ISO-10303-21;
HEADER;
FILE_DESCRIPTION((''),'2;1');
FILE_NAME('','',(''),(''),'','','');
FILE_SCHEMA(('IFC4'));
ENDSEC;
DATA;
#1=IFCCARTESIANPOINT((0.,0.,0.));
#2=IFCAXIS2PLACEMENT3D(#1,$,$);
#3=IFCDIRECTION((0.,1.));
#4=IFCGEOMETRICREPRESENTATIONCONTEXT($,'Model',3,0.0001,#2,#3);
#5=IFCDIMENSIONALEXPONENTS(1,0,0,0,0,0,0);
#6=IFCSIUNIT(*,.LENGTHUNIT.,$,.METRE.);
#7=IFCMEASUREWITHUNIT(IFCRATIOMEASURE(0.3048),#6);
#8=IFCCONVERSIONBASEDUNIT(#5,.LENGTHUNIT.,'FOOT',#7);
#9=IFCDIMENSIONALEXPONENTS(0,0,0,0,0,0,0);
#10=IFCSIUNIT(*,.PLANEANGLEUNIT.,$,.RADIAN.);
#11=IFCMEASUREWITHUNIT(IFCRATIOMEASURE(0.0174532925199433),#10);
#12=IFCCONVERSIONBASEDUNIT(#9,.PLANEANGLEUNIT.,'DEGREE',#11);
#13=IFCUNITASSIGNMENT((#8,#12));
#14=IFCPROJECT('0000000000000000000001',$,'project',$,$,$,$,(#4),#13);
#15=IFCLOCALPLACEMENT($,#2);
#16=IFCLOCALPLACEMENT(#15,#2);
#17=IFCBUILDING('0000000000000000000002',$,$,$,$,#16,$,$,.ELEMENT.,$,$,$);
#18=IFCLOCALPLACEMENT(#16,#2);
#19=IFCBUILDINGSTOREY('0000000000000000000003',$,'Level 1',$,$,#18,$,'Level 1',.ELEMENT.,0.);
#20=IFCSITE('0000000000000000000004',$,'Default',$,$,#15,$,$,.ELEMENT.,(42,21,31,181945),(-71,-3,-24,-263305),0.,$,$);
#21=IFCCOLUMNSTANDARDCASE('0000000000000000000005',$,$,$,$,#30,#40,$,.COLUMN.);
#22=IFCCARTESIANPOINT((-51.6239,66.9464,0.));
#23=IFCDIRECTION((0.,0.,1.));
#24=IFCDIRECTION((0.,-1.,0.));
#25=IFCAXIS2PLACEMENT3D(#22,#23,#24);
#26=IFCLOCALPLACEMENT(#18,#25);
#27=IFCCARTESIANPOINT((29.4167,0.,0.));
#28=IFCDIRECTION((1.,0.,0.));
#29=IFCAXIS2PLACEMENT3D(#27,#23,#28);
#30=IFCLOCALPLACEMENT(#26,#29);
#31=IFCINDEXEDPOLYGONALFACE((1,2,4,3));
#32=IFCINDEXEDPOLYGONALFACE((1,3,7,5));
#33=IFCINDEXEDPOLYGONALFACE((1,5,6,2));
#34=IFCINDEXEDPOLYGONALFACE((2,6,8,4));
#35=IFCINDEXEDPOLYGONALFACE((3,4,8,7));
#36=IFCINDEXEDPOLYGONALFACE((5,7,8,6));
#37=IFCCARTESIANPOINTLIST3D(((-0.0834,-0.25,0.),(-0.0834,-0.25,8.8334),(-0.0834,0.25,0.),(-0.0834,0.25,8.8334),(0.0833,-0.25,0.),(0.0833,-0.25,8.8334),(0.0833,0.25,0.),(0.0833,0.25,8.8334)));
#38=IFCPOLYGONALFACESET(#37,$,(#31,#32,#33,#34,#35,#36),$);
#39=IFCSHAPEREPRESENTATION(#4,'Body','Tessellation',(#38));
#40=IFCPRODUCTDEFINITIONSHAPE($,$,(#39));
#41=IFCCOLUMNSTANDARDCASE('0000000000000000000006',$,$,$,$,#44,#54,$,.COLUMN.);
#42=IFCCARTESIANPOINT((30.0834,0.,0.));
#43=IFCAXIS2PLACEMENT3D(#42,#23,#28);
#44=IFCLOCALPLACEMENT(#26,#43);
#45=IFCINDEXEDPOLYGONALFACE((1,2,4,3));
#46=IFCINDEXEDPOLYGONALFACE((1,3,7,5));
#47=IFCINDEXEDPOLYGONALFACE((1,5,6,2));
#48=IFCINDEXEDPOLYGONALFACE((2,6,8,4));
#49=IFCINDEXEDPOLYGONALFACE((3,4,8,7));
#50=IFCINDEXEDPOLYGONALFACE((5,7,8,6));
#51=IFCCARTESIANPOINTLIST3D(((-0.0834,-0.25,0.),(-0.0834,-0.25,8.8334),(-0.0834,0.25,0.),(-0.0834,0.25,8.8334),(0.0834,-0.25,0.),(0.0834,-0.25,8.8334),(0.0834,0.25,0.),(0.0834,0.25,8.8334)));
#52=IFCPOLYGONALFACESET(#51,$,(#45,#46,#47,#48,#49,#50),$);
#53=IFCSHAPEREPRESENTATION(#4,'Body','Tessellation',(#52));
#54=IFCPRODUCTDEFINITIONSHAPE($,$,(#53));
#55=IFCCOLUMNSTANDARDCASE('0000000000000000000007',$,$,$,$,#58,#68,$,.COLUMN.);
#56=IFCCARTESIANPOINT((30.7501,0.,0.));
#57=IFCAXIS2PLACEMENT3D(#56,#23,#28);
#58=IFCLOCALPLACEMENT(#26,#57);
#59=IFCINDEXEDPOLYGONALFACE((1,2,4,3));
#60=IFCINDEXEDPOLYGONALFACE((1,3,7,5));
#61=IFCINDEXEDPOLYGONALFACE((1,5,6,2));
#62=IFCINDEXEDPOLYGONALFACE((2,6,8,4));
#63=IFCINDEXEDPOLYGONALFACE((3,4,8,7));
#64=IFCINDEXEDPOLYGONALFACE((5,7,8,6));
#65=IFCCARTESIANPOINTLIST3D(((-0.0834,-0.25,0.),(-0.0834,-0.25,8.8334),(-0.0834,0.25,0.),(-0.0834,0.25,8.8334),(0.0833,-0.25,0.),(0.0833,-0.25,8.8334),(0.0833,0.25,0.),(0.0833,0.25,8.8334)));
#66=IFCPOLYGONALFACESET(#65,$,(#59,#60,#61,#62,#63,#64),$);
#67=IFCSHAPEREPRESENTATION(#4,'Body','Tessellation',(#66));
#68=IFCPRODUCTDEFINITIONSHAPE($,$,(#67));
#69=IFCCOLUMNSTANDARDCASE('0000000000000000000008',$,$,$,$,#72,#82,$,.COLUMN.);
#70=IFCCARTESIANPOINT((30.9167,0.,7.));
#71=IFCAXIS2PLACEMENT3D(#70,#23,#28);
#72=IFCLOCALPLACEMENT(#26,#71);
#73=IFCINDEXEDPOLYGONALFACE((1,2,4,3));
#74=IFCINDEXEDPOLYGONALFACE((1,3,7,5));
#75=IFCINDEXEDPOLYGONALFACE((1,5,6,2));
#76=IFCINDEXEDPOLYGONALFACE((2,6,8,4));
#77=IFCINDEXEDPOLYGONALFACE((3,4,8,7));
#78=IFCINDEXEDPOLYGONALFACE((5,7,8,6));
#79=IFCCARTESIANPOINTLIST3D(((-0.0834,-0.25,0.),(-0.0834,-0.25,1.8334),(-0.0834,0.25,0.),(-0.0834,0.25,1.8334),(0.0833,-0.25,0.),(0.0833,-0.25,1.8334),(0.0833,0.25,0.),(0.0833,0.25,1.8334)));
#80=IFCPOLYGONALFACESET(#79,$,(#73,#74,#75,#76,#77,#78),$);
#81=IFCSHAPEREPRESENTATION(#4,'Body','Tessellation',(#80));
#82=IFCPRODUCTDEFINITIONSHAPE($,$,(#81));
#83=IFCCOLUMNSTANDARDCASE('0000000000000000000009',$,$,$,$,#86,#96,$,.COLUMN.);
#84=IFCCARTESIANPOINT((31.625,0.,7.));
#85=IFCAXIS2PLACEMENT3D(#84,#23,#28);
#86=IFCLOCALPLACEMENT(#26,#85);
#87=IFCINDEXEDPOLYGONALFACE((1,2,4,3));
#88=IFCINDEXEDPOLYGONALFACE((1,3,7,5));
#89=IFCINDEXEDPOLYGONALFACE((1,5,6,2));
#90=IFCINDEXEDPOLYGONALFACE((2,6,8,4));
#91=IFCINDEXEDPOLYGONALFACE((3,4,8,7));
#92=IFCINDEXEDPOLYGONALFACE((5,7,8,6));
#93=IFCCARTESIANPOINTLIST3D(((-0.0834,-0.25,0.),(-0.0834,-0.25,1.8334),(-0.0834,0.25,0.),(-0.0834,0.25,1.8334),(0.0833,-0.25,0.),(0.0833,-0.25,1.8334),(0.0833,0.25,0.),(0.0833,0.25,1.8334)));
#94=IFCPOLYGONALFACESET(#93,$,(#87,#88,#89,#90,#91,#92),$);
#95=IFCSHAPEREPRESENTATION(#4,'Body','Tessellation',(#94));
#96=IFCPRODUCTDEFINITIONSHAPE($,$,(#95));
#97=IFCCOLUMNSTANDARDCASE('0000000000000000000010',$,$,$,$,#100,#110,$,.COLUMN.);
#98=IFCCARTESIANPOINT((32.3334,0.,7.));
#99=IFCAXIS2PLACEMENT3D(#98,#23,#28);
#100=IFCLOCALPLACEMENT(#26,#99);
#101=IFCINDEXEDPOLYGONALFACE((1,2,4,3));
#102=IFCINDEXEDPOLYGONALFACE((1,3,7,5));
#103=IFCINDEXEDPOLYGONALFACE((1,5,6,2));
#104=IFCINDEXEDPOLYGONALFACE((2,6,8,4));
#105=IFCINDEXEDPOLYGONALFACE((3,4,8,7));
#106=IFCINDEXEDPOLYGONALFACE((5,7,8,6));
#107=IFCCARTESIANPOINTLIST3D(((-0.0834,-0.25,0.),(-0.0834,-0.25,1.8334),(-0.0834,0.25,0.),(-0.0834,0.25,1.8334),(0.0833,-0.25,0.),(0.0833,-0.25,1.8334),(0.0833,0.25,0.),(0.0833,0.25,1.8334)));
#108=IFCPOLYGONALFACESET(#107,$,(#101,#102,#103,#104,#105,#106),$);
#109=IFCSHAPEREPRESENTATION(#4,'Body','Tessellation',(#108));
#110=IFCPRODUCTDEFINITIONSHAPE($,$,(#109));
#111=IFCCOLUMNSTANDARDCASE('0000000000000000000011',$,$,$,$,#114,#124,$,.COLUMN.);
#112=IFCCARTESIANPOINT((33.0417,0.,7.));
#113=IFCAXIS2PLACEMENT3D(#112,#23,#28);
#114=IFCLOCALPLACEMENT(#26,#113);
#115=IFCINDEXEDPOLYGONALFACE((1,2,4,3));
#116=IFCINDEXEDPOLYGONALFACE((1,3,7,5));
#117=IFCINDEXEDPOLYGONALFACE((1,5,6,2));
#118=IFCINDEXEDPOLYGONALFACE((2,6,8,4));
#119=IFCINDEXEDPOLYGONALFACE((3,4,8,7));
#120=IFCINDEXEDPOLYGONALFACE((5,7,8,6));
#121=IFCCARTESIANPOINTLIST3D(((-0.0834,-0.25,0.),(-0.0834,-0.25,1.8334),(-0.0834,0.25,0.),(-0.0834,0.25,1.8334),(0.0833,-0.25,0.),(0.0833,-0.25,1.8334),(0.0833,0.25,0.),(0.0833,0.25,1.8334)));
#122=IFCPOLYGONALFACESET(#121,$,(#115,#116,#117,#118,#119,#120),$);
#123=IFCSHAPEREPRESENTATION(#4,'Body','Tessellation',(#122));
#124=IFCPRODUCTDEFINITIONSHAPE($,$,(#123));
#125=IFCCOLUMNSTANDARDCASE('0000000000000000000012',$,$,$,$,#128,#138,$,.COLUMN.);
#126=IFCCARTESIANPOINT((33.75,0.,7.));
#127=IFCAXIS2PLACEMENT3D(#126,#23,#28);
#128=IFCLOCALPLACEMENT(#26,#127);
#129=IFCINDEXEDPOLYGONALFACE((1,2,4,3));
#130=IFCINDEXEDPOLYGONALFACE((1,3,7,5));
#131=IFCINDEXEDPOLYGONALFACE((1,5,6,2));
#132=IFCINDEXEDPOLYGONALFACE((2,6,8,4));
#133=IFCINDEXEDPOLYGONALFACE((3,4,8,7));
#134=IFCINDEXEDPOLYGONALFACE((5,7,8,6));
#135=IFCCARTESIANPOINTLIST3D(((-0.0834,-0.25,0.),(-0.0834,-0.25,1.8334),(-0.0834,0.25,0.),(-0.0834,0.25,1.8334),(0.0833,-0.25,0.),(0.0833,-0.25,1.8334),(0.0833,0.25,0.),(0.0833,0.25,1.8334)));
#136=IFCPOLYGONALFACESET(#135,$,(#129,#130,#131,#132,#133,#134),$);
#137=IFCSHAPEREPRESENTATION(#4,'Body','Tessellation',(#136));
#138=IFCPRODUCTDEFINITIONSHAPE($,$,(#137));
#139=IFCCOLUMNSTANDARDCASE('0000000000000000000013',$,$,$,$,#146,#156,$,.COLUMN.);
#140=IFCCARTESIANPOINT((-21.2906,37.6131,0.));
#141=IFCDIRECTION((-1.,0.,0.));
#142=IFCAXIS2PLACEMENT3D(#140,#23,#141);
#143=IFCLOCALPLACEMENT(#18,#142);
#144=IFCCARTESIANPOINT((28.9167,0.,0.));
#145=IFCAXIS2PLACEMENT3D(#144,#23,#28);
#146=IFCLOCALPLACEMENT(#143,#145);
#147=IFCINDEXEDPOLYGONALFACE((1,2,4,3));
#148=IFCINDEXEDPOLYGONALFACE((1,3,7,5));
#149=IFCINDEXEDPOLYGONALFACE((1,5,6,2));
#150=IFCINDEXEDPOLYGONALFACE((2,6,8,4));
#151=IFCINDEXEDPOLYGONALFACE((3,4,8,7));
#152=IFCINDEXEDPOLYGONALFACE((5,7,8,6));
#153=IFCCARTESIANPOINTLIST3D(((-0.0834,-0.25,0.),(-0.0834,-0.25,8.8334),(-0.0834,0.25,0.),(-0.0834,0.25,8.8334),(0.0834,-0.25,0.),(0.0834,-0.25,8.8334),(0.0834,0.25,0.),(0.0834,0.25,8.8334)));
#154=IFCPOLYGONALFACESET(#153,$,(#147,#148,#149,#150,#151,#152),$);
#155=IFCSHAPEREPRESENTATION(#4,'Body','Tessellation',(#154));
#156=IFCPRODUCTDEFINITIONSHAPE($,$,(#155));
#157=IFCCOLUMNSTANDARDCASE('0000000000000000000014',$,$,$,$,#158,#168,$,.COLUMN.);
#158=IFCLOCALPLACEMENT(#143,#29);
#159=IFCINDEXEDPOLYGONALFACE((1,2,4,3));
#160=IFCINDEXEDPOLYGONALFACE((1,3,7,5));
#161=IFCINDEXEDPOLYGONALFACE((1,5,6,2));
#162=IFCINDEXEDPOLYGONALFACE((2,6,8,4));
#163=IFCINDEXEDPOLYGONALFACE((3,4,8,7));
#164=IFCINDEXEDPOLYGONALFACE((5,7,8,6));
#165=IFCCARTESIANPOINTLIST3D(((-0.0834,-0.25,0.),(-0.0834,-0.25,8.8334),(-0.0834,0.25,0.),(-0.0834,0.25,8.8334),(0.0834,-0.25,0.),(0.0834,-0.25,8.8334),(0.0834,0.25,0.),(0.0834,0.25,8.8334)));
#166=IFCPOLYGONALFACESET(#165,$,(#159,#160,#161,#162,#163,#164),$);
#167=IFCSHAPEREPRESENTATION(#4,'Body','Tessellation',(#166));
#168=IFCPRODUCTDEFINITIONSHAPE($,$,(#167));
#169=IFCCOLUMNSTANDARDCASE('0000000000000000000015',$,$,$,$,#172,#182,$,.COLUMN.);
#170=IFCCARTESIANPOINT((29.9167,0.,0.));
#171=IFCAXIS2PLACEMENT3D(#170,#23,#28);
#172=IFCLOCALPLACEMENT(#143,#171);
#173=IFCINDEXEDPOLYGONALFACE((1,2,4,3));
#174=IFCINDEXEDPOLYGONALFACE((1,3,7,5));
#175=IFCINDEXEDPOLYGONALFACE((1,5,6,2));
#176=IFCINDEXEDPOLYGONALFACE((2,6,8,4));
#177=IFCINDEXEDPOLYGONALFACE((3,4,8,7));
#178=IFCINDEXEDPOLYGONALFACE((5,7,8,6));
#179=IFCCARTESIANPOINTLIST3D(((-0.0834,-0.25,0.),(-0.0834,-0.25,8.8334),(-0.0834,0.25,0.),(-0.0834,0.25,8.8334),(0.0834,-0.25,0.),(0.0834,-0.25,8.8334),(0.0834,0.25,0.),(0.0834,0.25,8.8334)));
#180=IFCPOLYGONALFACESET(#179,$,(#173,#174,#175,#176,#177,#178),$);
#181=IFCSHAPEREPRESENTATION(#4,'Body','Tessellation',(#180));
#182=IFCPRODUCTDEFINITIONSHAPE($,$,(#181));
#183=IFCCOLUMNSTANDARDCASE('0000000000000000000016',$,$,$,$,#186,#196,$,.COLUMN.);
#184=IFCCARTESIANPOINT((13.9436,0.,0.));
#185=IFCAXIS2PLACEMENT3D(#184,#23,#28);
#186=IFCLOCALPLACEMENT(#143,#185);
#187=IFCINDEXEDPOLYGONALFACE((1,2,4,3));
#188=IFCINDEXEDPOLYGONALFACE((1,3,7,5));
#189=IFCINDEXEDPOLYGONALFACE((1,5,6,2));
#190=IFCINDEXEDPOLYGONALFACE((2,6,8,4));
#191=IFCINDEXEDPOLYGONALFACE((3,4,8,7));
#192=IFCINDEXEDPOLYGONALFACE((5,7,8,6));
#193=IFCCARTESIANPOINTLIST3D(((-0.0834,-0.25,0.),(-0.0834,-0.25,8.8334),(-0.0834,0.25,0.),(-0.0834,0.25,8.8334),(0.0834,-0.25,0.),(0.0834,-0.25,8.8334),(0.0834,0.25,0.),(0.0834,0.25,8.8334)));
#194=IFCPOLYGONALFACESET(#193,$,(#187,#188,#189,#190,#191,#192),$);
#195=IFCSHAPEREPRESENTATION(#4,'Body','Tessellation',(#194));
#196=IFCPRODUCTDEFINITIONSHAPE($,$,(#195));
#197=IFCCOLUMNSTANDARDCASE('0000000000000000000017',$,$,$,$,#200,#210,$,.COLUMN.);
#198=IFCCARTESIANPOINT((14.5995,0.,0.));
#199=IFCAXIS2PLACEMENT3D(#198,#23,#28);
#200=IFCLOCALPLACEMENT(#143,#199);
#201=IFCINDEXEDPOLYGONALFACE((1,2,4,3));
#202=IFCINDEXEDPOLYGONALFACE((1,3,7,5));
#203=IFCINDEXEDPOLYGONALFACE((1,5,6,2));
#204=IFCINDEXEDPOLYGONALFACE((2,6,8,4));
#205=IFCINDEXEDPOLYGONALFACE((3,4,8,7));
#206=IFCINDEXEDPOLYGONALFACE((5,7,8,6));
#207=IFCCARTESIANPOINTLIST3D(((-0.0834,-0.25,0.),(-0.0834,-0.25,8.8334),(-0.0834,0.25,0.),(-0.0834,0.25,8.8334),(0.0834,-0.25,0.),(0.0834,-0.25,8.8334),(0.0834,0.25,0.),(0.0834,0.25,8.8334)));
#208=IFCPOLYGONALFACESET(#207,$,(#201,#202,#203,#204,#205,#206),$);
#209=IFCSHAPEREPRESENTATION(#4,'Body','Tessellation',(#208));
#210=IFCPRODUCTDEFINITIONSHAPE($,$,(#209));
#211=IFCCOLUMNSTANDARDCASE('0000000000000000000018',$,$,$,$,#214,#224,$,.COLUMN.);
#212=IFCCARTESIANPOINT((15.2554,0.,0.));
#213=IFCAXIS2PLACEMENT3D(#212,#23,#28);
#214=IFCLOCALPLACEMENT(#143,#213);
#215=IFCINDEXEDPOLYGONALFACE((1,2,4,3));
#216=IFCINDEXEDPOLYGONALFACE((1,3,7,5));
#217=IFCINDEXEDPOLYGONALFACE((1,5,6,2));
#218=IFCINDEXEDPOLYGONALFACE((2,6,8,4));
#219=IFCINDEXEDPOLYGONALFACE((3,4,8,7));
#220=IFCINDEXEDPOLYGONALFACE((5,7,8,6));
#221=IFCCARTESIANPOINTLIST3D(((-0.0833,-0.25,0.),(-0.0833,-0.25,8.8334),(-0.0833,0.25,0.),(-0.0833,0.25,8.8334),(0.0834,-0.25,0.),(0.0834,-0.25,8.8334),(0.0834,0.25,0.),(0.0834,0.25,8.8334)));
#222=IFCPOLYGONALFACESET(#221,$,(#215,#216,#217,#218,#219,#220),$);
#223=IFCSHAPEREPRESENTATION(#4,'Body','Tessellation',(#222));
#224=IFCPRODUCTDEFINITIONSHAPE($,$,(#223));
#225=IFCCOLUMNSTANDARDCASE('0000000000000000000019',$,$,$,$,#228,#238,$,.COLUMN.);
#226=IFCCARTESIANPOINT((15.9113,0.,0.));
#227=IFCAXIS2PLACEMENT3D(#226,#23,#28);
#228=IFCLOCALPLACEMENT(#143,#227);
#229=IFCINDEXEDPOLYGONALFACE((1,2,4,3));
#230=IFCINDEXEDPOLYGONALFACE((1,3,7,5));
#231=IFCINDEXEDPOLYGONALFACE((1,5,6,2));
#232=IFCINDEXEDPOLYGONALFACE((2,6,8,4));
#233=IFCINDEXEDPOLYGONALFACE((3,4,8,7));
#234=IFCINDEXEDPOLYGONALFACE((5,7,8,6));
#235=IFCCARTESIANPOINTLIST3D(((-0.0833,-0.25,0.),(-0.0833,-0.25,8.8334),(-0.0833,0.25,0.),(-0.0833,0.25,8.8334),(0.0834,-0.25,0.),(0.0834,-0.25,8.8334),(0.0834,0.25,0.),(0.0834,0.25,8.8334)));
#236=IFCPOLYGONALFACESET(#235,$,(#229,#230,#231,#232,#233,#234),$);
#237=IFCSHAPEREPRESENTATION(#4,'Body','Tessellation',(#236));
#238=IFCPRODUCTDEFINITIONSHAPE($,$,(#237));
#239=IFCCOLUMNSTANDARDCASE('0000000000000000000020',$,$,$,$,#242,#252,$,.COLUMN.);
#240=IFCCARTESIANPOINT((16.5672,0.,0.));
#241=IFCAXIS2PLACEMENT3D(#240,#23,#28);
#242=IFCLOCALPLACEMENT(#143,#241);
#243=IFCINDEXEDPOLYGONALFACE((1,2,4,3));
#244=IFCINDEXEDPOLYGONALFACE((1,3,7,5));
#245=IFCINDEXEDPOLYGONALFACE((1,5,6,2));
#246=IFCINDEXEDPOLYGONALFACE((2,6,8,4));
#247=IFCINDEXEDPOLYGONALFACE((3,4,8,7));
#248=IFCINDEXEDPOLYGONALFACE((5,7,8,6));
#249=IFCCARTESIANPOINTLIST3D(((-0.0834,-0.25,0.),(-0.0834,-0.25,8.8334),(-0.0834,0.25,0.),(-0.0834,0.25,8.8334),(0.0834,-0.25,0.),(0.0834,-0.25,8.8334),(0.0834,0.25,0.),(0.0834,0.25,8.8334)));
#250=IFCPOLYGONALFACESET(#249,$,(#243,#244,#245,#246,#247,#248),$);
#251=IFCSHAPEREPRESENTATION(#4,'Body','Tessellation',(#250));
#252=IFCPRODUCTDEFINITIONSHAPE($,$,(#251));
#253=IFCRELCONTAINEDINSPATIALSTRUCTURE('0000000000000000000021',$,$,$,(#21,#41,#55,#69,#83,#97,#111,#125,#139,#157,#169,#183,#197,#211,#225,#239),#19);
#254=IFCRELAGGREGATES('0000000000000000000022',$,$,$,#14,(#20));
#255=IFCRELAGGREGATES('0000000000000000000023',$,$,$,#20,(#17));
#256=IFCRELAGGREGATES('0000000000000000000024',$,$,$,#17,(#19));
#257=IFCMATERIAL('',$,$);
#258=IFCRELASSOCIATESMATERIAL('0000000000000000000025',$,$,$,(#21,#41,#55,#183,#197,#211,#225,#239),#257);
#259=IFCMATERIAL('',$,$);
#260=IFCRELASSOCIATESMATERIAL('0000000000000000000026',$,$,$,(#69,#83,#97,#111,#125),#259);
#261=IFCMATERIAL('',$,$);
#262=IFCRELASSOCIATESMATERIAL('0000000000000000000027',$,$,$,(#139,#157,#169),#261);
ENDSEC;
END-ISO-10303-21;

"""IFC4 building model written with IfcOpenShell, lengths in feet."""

from ifc_helpers import new_model, entity, si_unit, converted_unit, direction, frame, origin, place, context, project, spatial, rectangle, extrude, material, element, save


model = new_model("IFC4")

# Units and contexts
model_context = context("Model", 3, precision=0.0001, world=origin(), true_north=direction((0.0, 1.0)))
ifc_project = project(units=[converted_unit("LENGTHUNIT", "FOOT", entity("IfcRatioMeasure", 0.3048), si_unit("LENGTHUNIT", "METRE"), dimensions=[1, 0, 0, 0, 0, 0, 0]), converted_unit("PLANEANGLEUNIT", "DEGREE", entity("IfcRatioMeasure", 0.0174532925199433), si_unit("PLANEANGLEUNIT", "RADIAN"), dimensions=[0, 0, 0, 0, 0, 0, 0])], contexts=[model_context])

# Site, building, storey
site_placement = place(None, origin())
site = spatial("IfcSite", under=ifc_project, at=site_placement, Name="Default", CompositionType="ELEMENT", RefLatitude=(42, 21, 31, 181945), RefLongitude=(-71, -3, -24, -263305), RefElevation=0.0)
building_placement = place(site_placement, origin())
building = spatial("IfcBuilding", under=site, at=building_placement, CompositionType="ELEMENT")
storey_placement = place(building_placement, origin())
storey = spatial("IfcBuildingStorey", under=building, at=storey_placement, Name="Level 1", LongName="Level 1", CompositionType="ELEMENT", Elevation=0.0)

# Columns
ifc_material_1 = material(Name="")
placement_1 = place(storey_placement, frame((-51.6239, 66.9464, 0.0), z_axis=(0.0, 0.0, 1.0), x_axis=(0.0, -1.0, 0.0)))
for number, where, z_axis, x_axis in (
    (1, (29.4167, 0.0, 0.0), (0.0, 0.0, 1.0), (1.0, 0.0, 0.0)),
    (2, (30.0834, 0.0, 0.0), (0.0, 0.0, 1.0), (1.0, 0.0, 0.0)),
    (3, (30.7501, 0.0, 0.0), (0.0, 0.0, 1.0), (1.0, 0.0, 0.0)),
):
    element("IfcColumnStandardCase", number, at=place(placement_1, frame(where, z_axis=z_axis, x_axis=x_axis)), inside=storey, material=ifc_material_1, PredefinedType="COLUMN", context=model_context, shape_type="SweptSolid", body=[
        extrude(rectangle(XDim=0.1667, YDim=0.5), origin(), (0.0, 0.0, 1.0), 8.8334),
    ])
ifc_material_2 = material(Name="")
for number, where, z_axis, x_axis in (
    (4, (30.9167, 0.0, 7.0), (0.0, 0.0, 1.0), (1.0, 0.0, 0.0)),
    (5, (31.625, 0.0, 7.0), (0.0, 0.0, 1.0), (1.0, 0.0, 0.0)),
    (6, (32.3334, 0.0, 7.0), (0.0, 0.0, 1.0), (1.0, 0.0, 0.0)),
    (7, (33.0417, 0.0, 7.0), (0.0, 0.0, 1.0), (1.0, 0.0, 0.0)),
    (8, (33.75, 0.0, 7.0), (0.0, 0.0, 1.0), (1.0, 0.0, 0.0)),
):
    element("IfcColumnStandardCase", number, at=place(placement_1, frame(where, z_axis=z_axis, x_axis=x_axis)), inside=storey, material=ifc_material_2, PredefinedType="COLUMN", context=model_context, shape_type="SweptSolid", body=[
        extrude(rectangle(XDim=0.1667, YDim=0.5), origin(), (0.0, 0.0, 1.0), 1.8334),
    ])
ifc_material_3 = material(Name="")
placement_2 = place(storey_placement, frame((-21.2906, 37.6131, 0.0), z_axis=(0.0, 0.0, 1.0), x_axis=(-1.0, 0.0, 0.0)))
for number, where, z_axis, x_axis in (
    (9, (28.9167, 0.0, 0.0), (0.0, 0.0, 1.0), (1.0, 0.0, 0.0)),
    (10, (29.4167, 0.0, 0.0), (0.0, 0.0, 1.0), (1.0, 0.0, 0.0)),
    (11, (29.9167, 0.0, 0.0), (0.0, 0.0, 1.0), (1.0, 0.0, 0.0)),
):
    element("IfcColumnStandardCase", number, at=place(placement_2, frame(where, z_axis=z_axis, x_axis=x_axis)), inside=storey, material=ifc_material_3, PredefinedType="COLUMN", context=model_context, shape_type="SweptSolid", body=[
        extrude(rectangle(XDim=0.1667, YDim=0.5), origin(), (0.0, 0.0, 1.0), 8.8334),
    ])
for number, where, z_axis, x_axis in (
    (12, (13.9436, 0.0, 0.0), (0.0, 0.0, 1.0), (1.0, 0.0, 0.0)),
    (13, (14.5995, 0.0, 0.0), (0.0, 0.0, 1.0), (1.0, 0.0, 0.0)),
    (14, (15.2554, 0.0, 0.0), (0.0, 0.0, 1.0), (1.0, 0.0, 0.0)),
    (15, (15.9113, 0.0, 0.0), (0.0, 0.0, 1.0), (1.0, 0.0, 0.0)),
    (16, (16.5672, 0.0, 0.0), (0.0, 0.0, 1.0), (1.0, 0.0, 0.0)),
):
    element("IfcColumnStandardCase", number, at=place(placement_2, frame(where, z_axis=z_axis, x_axis=x_axis)), inside=storey, material=ifc_material_1, PredefinedType="COLUMN", context=model_context, shape_type="SweptSolid", body=[
        extrude(rectangle(XDim=0.1667, YDim=0.5), origin(), (0.0, 0.0, 1.0), 8.8334),
    ])

save(model, "model.ifc")
